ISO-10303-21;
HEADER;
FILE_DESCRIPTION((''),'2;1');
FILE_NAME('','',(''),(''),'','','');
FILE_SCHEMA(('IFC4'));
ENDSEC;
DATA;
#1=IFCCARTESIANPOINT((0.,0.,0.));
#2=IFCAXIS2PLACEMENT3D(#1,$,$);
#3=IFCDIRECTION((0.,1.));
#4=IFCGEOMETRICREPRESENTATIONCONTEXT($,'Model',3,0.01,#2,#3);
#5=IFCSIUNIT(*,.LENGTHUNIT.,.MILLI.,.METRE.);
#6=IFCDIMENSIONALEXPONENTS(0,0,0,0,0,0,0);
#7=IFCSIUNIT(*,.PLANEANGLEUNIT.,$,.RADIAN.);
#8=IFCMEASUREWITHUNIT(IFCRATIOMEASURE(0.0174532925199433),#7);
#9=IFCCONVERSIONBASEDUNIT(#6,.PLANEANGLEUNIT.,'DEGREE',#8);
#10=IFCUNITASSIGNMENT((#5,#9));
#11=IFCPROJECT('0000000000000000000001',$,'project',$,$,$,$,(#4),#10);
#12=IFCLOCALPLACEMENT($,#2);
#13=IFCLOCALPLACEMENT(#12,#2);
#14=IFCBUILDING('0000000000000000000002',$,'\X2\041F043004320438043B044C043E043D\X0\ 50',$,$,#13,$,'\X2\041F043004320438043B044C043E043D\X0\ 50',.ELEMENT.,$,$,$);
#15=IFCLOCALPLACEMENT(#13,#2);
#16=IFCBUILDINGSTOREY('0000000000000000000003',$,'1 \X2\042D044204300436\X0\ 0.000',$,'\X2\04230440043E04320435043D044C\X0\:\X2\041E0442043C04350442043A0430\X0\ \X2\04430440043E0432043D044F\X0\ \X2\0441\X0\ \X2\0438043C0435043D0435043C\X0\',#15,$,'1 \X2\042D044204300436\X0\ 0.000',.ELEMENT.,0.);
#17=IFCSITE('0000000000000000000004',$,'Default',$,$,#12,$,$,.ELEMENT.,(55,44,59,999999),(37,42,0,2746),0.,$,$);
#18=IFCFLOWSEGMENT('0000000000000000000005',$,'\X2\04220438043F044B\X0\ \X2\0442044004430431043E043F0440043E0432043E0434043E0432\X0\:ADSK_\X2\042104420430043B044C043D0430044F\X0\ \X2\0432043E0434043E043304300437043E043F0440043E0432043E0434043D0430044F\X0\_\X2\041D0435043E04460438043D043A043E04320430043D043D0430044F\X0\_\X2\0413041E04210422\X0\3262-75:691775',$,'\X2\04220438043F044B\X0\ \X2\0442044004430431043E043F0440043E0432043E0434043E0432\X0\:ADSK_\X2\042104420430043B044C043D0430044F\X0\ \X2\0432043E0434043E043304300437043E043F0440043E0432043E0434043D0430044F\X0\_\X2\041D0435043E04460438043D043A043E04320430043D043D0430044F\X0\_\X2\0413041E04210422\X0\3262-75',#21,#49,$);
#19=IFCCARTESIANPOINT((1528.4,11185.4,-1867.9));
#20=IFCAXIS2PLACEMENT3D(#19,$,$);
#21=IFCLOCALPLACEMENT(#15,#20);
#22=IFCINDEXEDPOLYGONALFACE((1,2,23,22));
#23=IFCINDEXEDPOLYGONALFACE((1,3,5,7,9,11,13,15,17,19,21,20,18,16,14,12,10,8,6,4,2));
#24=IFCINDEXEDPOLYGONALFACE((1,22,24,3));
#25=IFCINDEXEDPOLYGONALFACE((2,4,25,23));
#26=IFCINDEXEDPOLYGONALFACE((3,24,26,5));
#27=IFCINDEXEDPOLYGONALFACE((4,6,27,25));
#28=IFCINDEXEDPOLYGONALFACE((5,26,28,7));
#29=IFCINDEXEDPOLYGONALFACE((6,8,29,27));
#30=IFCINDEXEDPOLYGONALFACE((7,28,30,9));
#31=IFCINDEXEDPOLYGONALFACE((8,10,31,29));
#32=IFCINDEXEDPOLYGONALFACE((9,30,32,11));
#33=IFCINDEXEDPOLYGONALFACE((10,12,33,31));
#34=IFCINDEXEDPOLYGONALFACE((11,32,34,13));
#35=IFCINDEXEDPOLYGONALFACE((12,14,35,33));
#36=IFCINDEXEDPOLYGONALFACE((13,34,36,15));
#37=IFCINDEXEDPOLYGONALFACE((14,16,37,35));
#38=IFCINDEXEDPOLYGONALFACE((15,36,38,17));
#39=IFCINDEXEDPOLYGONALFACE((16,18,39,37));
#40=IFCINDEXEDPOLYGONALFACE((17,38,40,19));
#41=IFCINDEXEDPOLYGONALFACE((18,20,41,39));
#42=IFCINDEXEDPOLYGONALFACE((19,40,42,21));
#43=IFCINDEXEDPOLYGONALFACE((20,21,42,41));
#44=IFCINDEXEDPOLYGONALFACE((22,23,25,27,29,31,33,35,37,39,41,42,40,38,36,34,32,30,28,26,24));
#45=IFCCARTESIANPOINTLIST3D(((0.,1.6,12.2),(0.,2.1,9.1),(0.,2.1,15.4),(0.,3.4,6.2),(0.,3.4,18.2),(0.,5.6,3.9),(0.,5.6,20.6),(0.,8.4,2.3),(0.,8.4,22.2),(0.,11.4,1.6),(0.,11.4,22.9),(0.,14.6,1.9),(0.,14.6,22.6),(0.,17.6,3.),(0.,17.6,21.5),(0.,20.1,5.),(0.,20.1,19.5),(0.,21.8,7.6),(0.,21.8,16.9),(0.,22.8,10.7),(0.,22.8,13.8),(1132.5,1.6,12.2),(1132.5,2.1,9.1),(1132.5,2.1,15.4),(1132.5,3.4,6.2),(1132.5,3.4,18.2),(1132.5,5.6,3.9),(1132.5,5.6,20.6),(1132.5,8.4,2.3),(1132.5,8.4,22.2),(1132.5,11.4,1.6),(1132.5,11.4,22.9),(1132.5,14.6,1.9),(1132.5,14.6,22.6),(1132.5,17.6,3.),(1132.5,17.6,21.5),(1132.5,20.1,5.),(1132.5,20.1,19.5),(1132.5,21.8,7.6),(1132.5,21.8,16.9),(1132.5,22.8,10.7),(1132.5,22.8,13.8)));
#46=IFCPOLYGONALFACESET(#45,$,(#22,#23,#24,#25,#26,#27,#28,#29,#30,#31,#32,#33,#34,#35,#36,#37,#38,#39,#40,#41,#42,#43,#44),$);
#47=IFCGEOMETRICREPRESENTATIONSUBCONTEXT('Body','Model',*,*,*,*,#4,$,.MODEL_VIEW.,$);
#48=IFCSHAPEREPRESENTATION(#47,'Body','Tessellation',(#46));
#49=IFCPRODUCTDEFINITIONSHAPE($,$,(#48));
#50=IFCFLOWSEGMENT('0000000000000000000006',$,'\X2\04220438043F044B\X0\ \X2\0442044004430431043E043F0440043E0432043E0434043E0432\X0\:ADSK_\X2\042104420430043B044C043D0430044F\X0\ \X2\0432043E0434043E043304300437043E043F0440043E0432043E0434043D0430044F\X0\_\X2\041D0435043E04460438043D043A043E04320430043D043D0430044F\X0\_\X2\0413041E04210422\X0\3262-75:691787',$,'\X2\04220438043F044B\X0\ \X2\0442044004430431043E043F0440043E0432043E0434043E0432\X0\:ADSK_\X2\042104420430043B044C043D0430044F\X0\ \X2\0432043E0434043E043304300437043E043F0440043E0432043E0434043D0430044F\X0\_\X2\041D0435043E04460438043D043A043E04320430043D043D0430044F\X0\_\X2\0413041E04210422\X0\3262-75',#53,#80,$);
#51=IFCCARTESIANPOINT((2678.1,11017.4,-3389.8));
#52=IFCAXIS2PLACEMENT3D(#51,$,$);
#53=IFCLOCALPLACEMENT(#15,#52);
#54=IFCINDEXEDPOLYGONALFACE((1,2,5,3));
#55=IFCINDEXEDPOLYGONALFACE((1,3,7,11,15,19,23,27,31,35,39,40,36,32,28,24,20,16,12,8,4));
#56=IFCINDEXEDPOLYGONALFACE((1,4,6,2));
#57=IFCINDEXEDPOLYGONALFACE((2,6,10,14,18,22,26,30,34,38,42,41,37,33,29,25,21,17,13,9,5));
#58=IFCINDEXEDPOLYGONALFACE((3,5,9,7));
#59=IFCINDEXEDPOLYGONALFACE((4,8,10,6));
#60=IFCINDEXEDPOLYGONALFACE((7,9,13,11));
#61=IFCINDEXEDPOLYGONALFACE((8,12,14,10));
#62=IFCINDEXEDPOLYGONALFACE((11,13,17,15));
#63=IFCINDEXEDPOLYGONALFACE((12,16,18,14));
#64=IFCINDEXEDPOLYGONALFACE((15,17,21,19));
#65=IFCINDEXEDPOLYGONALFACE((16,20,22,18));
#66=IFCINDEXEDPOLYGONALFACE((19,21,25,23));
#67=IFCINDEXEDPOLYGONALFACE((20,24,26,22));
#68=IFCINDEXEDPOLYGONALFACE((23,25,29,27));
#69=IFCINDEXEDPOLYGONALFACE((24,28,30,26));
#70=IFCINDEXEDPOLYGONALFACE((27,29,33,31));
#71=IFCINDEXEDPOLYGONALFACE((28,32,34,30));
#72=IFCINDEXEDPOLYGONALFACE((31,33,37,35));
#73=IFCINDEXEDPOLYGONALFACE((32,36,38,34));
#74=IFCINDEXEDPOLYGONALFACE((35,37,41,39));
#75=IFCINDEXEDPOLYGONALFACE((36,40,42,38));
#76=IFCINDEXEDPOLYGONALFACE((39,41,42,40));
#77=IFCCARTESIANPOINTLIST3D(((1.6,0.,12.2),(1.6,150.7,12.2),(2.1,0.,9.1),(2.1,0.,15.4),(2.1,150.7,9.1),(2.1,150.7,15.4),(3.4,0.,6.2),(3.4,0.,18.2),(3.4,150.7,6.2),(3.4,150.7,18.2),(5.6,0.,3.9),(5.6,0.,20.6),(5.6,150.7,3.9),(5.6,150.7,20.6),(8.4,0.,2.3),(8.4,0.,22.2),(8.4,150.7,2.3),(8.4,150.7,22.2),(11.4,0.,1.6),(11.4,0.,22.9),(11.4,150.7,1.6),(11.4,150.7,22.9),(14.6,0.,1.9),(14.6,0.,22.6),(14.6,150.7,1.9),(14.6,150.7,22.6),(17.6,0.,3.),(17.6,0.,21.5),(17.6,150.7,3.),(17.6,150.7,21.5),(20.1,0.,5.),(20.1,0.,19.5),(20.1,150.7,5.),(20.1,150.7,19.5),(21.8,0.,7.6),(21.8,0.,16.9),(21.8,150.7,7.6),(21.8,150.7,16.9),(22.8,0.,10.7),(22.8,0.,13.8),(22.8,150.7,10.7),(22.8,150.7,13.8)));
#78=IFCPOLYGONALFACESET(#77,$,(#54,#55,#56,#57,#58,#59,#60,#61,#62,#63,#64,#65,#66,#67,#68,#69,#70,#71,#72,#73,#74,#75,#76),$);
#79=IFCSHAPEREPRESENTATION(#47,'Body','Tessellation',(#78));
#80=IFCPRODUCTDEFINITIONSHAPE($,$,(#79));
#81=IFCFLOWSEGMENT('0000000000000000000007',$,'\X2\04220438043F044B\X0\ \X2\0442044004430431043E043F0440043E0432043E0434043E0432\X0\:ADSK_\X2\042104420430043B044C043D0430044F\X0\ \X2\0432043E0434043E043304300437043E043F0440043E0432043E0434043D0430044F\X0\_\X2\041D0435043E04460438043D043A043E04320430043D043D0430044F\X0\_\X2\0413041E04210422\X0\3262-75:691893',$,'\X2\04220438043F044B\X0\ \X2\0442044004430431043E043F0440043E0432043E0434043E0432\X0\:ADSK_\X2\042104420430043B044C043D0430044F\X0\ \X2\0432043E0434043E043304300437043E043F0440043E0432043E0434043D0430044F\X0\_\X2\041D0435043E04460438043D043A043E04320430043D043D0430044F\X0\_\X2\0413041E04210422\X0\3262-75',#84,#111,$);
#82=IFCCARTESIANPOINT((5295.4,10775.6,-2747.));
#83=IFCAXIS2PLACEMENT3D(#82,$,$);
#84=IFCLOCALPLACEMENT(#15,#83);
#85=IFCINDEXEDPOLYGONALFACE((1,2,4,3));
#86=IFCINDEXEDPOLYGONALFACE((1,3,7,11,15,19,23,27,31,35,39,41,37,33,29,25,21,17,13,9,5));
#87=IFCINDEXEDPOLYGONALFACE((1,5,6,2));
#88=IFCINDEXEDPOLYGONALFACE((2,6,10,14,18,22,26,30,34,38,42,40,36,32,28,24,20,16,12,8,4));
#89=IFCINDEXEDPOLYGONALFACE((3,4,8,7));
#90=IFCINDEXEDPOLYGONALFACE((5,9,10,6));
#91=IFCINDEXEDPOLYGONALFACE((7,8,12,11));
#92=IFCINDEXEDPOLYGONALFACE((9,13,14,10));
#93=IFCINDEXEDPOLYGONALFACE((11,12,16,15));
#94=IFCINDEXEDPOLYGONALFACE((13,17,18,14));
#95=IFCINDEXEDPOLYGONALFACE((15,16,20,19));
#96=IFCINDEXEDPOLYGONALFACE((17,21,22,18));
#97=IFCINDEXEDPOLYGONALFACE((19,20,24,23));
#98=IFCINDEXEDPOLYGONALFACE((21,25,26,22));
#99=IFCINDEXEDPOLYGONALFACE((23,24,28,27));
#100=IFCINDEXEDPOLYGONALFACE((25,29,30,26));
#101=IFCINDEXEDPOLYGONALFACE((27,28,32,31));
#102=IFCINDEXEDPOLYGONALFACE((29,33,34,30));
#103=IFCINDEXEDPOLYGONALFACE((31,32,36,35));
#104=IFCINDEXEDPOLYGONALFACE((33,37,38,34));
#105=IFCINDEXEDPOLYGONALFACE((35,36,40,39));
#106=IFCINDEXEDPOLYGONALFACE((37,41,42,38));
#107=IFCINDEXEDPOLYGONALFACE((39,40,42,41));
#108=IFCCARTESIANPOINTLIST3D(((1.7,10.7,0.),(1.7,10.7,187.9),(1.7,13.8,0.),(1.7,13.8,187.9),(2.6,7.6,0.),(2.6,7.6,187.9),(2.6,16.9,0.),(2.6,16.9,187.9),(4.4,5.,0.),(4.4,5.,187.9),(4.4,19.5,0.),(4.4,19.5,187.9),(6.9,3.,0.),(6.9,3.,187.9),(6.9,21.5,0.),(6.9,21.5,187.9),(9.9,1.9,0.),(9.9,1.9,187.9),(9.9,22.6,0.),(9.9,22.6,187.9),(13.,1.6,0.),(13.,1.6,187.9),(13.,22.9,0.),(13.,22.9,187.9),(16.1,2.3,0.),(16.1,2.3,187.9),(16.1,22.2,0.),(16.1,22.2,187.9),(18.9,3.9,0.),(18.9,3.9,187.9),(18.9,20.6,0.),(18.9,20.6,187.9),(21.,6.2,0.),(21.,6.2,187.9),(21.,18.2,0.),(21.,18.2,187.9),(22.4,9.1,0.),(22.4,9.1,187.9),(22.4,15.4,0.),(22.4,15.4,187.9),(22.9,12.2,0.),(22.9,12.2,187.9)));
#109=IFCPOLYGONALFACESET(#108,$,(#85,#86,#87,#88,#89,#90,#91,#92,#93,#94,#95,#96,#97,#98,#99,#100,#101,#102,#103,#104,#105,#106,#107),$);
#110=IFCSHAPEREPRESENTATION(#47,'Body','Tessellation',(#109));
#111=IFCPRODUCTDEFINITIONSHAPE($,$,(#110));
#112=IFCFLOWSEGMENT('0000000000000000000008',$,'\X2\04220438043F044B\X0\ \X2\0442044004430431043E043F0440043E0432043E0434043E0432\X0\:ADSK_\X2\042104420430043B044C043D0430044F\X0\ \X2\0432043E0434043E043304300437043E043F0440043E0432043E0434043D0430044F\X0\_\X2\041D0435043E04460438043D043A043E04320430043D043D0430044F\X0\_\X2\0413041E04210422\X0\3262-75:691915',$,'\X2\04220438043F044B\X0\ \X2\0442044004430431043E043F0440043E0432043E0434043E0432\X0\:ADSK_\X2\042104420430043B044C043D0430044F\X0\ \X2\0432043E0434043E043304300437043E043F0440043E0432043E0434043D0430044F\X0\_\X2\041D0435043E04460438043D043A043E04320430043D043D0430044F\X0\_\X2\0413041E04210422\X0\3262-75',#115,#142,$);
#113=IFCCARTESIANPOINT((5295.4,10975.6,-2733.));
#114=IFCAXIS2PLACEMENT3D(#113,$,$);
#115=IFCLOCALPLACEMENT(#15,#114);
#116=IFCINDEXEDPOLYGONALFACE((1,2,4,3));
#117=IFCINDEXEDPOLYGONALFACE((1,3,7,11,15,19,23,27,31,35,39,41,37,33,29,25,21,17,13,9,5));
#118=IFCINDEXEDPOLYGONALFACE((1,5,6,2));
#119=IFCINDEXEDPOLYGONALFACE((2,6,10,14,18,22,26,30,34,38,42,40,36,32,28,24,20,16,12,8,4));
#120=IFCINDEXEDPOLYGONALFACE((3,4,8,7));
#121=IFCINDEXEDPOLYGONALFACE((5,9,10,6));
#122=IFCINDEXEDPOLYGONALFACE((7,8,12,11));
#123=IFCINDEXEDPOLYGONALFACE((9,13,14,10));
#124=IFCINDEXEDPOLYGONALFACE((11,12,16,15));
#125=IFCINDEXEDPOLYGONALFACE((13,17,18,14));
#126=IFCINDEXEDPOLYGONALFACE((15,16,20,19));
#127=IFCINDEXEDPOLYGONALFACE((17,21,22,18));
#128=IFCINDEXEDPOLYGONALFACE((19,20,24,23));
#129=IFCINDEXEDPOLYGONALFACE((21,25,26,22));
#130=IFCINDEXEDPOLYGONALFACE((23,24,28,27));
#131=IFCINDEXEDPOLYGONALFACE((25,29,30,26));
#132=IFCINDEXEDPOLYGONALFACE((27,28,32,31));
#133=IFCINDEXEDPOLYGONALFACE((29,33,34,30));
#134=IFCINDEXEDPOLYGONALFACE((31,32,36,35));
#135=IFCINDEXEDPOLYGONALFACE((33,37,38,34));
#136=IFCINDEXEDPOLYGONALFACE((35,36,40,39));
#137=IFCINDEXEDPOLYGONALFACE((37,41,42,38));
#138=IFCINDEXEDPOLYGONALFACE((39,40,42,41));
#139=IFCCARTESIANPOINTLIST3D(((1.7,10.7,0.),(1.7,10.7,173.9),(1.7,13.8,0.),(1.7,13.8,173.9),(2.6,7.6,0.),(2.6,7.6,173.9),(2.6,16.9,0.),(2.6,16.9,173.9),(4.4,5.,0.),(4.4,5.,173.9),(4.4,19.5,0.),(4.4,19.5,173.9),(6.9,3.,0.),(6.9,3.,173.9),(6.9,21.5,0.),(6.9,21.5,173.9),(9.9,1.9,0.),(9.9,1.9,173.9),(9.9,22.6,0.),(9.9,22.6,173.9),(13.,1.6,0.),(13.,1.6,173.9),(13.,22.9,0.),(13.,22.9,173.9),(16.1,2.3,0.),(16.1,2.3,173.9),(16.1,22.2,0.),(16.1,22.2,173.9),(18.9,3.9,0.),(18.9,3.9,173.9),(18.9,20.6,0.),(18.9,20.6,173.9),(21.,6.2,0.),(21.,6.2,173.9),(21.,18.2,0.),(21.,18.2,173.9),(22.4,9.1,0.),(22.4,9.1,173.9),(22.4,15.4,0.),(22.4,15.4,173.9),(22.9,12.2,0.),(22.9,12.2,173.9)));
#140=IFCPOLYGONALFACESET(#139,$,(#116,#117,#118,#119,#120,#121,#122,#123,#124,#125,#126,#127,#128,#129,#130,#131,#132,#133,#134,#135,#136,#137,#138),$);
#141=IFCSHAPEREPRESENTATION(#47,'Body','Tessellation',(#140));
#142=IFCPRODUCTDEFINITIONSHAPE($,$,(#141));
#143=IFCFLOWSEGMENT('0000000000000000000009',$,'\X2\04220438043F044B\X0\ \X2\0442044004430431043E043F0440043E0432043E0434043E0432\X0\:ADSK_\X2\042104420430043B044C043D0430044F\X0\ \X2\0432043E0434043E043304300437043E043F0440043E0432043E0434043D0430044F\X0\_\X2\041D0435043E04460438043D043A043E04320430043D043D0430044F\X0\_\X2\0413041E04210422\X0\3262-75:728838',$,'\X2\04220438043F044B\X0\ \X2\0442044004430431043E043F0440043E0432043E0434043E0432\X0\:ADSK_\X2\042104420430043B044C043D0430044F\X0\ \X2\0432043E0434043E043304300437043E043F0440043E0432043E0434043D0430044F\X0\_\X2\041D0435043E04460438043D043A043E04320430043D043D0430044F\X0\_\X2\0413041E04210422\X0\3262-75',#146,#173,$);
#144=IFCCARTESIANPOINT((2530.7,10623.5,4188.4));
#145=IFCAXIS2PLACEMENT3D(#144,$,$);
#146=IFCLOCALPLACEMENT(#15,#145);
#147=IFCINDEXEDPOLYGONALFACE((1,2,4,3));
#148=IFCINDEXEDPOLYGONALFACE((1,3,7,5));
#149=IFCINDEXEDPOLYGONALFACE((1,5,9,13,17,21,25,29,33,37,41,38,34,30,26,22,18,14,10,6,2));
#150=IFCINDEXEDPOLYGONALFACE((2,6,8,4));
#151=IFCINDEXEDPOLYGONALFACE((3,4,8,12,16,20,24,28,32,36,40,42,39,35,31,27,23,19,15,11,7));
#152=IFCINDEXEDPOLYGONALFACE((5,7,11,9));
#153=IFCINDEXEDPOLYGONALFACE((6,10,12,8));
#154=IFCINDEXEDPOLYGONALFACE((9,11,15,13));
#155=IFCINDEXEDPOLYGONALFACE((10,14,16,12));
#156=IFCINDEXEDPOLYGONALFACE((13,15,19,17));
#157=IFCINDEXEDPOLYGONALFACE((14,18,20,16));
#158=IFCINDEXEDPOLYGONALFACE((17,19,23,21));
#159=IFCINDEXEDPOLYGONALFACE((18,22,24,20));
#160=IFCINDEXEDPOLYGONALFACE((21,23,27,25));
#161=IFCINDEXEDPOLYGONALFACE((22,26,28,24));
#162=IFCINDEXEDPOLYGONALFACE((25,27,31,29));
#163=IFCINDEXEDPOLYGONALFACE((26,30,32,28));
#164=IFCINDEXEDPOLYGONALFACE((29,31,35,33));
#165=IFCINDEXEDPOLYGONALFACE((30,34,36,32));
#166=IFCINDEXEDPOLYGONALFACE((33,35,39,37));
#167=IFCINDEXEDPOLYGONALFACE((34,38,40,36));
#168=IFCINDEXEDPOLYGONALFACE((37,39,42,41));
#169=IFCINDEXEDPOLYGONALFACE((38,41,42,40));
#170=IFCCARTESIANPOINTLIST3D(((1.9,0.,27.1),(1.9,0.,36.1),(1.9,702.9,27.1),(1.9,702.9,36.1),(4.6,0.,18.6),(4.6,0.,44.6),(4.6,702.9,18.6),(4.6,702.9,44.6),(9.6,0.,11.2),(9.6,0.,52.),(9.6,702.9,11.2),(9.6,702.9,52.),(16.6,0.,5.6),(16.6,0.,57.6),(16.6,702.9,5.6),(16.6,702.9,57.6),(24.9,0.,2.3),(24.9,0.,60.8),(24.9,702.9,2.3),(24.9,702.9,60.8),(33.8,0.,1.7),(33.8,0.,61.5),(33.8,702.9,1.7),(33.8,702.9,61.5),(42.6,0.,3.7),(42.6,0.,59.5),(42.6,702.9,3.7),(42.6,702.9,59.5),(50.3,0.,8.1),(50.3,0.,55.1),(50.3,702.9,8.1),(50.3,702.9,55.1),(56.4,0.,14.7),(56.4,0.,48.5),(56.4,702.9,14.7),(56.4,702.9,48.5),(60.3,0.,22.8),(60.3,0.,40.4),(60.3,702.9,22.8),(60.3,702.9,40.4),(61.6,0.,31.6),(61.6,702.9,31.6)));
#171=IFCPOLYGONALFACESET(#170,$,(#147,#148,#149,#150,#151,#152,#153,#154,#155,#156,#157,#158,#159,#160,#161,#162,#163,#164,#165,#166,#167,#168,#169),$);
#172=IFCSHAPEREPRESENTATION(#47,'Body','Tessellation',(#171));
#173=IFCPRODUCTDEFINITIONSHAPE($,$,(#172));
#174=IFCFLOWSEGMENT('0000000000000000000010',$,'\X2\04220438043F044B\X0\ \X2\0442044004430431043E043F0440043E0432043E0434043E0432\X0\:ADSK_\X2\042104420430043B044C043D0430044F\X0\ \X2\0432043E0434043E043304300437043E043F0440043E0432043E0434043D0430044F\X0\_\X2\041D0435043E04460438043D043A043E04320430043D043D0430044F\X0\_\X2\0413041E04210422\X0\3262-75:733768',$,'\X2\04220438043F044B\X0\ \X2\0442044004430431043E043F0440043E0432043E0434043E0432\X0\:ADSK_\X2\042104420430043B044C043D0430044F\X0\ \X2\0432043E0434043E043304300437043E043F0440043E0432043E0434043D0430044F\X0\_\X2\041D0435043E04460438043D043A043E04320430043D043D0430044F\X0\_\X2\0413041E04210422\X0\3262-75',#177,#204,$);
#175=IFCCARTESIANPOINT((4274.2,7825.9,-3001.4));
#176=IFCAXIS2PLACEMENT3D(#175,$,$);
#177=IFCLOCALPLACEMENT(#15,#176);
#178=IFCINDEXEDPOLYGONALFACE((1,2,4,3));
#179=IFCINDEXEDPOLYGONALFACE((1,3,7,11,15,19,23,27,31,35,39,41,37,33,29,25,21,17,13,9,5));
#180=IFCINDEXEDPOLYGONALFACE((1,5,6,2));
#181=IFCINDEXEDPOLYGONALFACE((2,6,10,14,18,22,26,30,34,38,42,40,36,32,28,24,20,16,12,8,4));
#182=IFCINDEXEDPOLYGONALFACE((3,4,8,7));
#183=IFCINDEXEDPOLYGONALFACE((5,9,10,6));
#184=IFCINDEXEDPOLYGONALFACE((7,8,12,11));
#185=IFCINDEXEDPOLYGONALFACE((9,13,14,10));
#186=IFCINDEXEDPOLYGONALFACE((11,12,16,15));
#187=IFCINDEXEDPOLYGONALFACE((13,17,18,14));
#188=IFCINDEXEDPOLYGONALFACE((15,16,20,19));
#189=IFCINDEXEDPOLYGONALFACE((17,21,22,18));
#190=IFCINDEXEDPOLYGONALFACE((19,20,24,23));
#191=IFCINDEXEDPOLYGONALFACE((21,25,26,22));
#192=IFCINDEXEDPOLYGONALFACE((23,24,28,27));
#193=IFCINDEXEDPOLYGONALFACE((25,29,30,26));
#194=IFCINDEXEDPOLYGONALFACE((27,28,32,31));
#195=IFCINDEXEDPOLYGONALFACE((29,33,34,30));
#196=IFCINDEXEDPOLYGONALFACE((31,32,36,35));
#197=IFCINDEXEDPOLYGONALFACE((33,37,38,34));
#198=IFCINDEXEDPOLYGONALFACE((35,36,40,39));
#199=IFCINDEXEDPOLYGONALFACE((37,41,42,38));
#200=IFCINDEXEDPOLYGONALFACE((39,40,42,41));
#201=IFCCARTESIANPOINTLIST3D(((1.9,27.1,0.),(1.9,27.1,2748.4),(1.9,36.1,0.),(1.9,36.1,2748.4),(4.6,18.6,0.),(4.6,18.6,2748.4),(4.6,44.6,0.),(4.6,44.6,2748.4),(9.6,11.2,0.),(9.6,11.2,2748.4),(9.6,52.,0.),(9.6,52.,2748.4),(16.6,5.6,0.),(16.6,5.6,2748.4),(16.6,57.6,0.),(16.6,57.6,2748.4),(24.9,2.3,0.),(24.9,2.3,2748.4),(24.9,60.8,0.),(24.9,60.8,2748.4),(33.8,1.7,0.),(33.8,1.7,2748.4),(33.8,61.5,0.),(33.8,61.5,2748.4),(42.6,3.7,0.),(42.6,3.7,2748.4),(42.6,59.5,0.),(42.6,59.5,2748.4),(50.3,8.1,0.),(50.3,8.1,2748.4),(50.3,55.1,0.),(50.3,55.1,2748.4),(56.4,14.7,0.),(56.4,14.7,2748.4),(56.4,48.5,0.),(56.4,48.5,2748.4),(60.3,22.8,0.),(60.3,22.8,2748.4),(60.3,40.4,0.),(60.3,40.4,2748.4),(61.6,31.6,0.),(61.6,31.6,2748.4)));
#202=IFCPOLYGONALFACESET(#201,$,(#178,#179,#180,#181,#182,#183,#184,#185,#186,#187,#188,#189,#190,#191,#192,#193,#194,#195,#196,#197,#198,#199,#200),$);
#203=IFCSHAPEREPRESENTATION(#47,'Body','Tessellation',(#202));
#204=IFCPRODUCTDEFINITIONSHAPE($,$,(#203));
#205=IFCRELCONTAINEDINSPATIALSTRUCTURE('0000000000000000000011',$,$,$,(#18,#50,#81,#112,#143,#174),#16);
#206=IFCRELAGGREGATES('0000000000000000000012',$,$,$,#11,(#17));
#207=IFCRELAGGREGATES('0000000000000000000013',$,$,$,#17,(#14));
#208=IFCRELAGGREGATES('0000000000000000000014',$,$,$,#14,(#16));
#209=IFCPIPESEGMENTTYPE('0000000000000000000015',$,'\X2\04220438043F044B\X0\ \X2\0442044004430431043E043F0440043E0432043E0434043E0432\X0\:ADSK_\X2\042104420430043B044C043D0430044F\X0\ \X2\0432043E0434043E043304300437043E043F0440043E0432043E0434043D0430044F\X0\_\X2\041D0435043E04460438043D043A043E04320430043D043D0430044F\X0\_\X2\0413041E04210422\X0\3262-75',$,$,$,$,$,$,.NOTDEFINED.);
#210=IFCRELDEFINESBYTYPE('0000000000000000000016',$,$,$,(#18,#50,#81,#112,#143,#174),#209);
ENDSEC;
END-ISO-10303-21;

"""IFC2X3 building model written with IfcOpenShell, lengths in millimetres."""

from ifc_helpers import new_model, entity, si_unit, converted_unit, direction, frame, frame_2d, origin, origin_2d_with_axis, place, context, subcontext, project, spatial, circle, extrude, type_object, element, save


model = new_model("IFC2X3")

# Units and contexts
model_context = context("Model", 3, precision=0.01, world=origin(), true_north=direction((0.0, 1.0)))
body_context = subcontext(model_context, "Body", "Model", "MODEL_VIEW")
ifc_project = project(units=[si_unit("LENGTHUNIT", "METRE", prefix="MILLI"), converted_unit("PLANEANGLEUNIT", "DEGREE", entity("IfcRatioMeasure", 0.0174532925199433), si_unit("PLANEANGLEUNIT", "RADIAN"), dimensions=[0, 0, 0, 0, 0, 0, 0])], contexts=[model_context])

# Site, building, storey
site_placement = place(None, origin())
site = spatial("IfcSite", under=ifc_project, at=site_placement, Name="Default", CompositionType="ELEMENT", RefLatitude=(55, 44, 59, 999999), RefLongitude=(37, 42, 0, 2746), RefElevation=0.0)
building_placement = place(site_placement, origin())
building = spatial("IfcBuilding", under=site, at=building_placement, Name="Павильон 50", LongName="Павильон 50", CompositionType="ELEMENT")
storey_placement = place(building_placement, origin())
storey = spatial("IfcBuildingStorey", under=building, at=storey_placement, Name="1 Этаж 0.000", ObjectType="Уровень:Отметка уровня с именем", LongName="1 Этаж 0.000", CompositionType="ELEMENT", Elevation=0.0)

# Flow segments
pipe_segment_type = type_object("IfcPipeSegmentType", Name="Типы трубопроводов:ADSK_Стальная водогазопроводная_Неоцинкованная_ГОСТ3262-75", PredefinedType="NOTDEFINED")
flow_segment_1_placement = place(storey_placement, frame((1528.4, 11185.4, -1867.9)))
element("IfcFlowSegment", 1, at=flow_segment_1_placement, inside=storey, type_object=pipe_segment_type, Name="Типы трубопроводов:ADSK_Стальная водогазопроводная_Неоцинкованная_ГОСТ3262-75:691775", ObjectType="Типы трубопроводов:ADSK_Стальная водогазопроводная_Неоцинкованная_ГОСТ3262-75", context=body_context, shape_type="SweptSolid", body=[
    extrude(circle(Radius=10.7, at=frame_2d((0.0, 0.0), x_axis=(1.0, 0.0))), frame((0.0, 12.2, 12.2), z_axis=(1.0, 0.0, 0.0), x_axis=(0.0, -1.0, 0.0)), (0.0, 0.0, 1.0), 1132.5),
])
flow_segment_2_placement = place(storey_placement, frame((2678.1, 11017.4, -3389.8)))
element("IfcFlowSegment", 2, at=flow_segment_2_placement, inside=storey, type_object=pipe_segment_type, Name="Типы трубопроводов:ADSK_Стальная водогазопроводная_Неоцинкованная_ГОСТ3262-75:691787", ObjectType="Типы трубопроводов:ADSK_Стальная водогазопроводная_Неоцинкованная_ГОСТ3262-75", context=body_context, shape_type="SweptSolid", body=[
    extrude(circle(Radius=10.7, at=origin_2d_with_axis()), frame((12.2, 0.0, 12.2), z_axis=(0.0, 1.0, 0.0), x_axis=(-1.0, 0.0, 0.0)), (0.0, 0.0, 1.0), 150.7),
])
flow_segment_3_placement = place(storey_placement, frame((5295.4, 10775.6, -2747.0)))
element("IfcFlowSegment", 3, at=flow_segment_3_placement, inside=storey, type_object=pipe_segment_type, Name="Типы трубопроводов:ADSK_Стальная водогазопроводная_Неоцинкованная_ГОСТ3262-75:691893", ObjectType="Типы трубопроводов:ADSK_Стальная водогазопроводная_Неоцинкованная_ГОСТ3262-75", context=body_context, shape_type="SweptSolid", body=[
    extrude(circle(Radius=10.7, at=origin_2d_with_axis()), frame((12.2, 12.2, 0.0)), (0.0, 0.0, 1.0), 187.9),
])
flow_segment_4_placement = place(storey_placement, frame((5295.4, 10975.6, -2733.0)))
element("IfcFlowSegment", 4, at=flow_segment_4_placement, inside=storey, type_object=pipe_segment_type, Name="Типы трубопроводов:ADSK_Стальная водогазопроводная_Неоцинкованная_ГОСТ3262-75:691915", ObjectType="Типы трубопроводов:ADSK_Стальная водогазопроводная_Неоцинкованная_ГОСТ3262-75", context=body_context, shape_type="SweptSolid", body=[
    extrude(circle(Radius=10.7, at=origin_2d_with_axis()), frame((12.2, 12.2, 0.0)), (0.0, 0.0, 1.0), 173.9),
])
flow_segment_5_placement = place(storey_placement, frame((2530.7, 10623.5, 4188.4)))
element("IfcFlowSegment", 5, at=flow_segment_5_placement, inside=storey, type_object=pipe_segment_type, Name="Типы трубопроводов:ADSK_Стальная водогазопроводная_Неоцинкованная_ГОСТ3262-75:728838", ObjectType="Типы трубопроводов:ADSK_Стальная водогазопроводная_Неоцинкованная_ГОСТ3262-75", context=body_context, shape_type="SweptSolid", body=[
    extrude(circle(Radius=30.0, at=frame_2d((0.0, 0.0), x_axis=(1.0, 0.0))), frame((31.6, 0.0, 31.6), z_axis=(0.0, 1.0, 0.0), x_axis=(1.0, 0.0, 0.0)), (0.0, 0.0, 1.0), 702.9),
])
flow_segment_6_placement = place(storey_placement, frame((4274.2, 7825.9, -3001.4)))
element("IfcFlowSegment", 6, at=flow_segment_6_placement, inside=storey, type_object=pipe_segment_type, Name="Типы трубопроводов:ADSK_Стальная водогазопроводная_Неоцинкованная_ГОСТ3262-75:733768", ObjectType="Типы трубопроводов:ADSK_Стальная водогазопроводная_Неоцинкованная_ГОСТ3262-75", context=body_context, shape_type="SweptSolid", body=[
    extrude(circle(Radius=30.0, at=origin_2d_with_axis()), frame((31.6, 31.6, 0.0)), (0.0, 0.0, 1.0), 2748.4),
])

save(model, "model.ifc")
